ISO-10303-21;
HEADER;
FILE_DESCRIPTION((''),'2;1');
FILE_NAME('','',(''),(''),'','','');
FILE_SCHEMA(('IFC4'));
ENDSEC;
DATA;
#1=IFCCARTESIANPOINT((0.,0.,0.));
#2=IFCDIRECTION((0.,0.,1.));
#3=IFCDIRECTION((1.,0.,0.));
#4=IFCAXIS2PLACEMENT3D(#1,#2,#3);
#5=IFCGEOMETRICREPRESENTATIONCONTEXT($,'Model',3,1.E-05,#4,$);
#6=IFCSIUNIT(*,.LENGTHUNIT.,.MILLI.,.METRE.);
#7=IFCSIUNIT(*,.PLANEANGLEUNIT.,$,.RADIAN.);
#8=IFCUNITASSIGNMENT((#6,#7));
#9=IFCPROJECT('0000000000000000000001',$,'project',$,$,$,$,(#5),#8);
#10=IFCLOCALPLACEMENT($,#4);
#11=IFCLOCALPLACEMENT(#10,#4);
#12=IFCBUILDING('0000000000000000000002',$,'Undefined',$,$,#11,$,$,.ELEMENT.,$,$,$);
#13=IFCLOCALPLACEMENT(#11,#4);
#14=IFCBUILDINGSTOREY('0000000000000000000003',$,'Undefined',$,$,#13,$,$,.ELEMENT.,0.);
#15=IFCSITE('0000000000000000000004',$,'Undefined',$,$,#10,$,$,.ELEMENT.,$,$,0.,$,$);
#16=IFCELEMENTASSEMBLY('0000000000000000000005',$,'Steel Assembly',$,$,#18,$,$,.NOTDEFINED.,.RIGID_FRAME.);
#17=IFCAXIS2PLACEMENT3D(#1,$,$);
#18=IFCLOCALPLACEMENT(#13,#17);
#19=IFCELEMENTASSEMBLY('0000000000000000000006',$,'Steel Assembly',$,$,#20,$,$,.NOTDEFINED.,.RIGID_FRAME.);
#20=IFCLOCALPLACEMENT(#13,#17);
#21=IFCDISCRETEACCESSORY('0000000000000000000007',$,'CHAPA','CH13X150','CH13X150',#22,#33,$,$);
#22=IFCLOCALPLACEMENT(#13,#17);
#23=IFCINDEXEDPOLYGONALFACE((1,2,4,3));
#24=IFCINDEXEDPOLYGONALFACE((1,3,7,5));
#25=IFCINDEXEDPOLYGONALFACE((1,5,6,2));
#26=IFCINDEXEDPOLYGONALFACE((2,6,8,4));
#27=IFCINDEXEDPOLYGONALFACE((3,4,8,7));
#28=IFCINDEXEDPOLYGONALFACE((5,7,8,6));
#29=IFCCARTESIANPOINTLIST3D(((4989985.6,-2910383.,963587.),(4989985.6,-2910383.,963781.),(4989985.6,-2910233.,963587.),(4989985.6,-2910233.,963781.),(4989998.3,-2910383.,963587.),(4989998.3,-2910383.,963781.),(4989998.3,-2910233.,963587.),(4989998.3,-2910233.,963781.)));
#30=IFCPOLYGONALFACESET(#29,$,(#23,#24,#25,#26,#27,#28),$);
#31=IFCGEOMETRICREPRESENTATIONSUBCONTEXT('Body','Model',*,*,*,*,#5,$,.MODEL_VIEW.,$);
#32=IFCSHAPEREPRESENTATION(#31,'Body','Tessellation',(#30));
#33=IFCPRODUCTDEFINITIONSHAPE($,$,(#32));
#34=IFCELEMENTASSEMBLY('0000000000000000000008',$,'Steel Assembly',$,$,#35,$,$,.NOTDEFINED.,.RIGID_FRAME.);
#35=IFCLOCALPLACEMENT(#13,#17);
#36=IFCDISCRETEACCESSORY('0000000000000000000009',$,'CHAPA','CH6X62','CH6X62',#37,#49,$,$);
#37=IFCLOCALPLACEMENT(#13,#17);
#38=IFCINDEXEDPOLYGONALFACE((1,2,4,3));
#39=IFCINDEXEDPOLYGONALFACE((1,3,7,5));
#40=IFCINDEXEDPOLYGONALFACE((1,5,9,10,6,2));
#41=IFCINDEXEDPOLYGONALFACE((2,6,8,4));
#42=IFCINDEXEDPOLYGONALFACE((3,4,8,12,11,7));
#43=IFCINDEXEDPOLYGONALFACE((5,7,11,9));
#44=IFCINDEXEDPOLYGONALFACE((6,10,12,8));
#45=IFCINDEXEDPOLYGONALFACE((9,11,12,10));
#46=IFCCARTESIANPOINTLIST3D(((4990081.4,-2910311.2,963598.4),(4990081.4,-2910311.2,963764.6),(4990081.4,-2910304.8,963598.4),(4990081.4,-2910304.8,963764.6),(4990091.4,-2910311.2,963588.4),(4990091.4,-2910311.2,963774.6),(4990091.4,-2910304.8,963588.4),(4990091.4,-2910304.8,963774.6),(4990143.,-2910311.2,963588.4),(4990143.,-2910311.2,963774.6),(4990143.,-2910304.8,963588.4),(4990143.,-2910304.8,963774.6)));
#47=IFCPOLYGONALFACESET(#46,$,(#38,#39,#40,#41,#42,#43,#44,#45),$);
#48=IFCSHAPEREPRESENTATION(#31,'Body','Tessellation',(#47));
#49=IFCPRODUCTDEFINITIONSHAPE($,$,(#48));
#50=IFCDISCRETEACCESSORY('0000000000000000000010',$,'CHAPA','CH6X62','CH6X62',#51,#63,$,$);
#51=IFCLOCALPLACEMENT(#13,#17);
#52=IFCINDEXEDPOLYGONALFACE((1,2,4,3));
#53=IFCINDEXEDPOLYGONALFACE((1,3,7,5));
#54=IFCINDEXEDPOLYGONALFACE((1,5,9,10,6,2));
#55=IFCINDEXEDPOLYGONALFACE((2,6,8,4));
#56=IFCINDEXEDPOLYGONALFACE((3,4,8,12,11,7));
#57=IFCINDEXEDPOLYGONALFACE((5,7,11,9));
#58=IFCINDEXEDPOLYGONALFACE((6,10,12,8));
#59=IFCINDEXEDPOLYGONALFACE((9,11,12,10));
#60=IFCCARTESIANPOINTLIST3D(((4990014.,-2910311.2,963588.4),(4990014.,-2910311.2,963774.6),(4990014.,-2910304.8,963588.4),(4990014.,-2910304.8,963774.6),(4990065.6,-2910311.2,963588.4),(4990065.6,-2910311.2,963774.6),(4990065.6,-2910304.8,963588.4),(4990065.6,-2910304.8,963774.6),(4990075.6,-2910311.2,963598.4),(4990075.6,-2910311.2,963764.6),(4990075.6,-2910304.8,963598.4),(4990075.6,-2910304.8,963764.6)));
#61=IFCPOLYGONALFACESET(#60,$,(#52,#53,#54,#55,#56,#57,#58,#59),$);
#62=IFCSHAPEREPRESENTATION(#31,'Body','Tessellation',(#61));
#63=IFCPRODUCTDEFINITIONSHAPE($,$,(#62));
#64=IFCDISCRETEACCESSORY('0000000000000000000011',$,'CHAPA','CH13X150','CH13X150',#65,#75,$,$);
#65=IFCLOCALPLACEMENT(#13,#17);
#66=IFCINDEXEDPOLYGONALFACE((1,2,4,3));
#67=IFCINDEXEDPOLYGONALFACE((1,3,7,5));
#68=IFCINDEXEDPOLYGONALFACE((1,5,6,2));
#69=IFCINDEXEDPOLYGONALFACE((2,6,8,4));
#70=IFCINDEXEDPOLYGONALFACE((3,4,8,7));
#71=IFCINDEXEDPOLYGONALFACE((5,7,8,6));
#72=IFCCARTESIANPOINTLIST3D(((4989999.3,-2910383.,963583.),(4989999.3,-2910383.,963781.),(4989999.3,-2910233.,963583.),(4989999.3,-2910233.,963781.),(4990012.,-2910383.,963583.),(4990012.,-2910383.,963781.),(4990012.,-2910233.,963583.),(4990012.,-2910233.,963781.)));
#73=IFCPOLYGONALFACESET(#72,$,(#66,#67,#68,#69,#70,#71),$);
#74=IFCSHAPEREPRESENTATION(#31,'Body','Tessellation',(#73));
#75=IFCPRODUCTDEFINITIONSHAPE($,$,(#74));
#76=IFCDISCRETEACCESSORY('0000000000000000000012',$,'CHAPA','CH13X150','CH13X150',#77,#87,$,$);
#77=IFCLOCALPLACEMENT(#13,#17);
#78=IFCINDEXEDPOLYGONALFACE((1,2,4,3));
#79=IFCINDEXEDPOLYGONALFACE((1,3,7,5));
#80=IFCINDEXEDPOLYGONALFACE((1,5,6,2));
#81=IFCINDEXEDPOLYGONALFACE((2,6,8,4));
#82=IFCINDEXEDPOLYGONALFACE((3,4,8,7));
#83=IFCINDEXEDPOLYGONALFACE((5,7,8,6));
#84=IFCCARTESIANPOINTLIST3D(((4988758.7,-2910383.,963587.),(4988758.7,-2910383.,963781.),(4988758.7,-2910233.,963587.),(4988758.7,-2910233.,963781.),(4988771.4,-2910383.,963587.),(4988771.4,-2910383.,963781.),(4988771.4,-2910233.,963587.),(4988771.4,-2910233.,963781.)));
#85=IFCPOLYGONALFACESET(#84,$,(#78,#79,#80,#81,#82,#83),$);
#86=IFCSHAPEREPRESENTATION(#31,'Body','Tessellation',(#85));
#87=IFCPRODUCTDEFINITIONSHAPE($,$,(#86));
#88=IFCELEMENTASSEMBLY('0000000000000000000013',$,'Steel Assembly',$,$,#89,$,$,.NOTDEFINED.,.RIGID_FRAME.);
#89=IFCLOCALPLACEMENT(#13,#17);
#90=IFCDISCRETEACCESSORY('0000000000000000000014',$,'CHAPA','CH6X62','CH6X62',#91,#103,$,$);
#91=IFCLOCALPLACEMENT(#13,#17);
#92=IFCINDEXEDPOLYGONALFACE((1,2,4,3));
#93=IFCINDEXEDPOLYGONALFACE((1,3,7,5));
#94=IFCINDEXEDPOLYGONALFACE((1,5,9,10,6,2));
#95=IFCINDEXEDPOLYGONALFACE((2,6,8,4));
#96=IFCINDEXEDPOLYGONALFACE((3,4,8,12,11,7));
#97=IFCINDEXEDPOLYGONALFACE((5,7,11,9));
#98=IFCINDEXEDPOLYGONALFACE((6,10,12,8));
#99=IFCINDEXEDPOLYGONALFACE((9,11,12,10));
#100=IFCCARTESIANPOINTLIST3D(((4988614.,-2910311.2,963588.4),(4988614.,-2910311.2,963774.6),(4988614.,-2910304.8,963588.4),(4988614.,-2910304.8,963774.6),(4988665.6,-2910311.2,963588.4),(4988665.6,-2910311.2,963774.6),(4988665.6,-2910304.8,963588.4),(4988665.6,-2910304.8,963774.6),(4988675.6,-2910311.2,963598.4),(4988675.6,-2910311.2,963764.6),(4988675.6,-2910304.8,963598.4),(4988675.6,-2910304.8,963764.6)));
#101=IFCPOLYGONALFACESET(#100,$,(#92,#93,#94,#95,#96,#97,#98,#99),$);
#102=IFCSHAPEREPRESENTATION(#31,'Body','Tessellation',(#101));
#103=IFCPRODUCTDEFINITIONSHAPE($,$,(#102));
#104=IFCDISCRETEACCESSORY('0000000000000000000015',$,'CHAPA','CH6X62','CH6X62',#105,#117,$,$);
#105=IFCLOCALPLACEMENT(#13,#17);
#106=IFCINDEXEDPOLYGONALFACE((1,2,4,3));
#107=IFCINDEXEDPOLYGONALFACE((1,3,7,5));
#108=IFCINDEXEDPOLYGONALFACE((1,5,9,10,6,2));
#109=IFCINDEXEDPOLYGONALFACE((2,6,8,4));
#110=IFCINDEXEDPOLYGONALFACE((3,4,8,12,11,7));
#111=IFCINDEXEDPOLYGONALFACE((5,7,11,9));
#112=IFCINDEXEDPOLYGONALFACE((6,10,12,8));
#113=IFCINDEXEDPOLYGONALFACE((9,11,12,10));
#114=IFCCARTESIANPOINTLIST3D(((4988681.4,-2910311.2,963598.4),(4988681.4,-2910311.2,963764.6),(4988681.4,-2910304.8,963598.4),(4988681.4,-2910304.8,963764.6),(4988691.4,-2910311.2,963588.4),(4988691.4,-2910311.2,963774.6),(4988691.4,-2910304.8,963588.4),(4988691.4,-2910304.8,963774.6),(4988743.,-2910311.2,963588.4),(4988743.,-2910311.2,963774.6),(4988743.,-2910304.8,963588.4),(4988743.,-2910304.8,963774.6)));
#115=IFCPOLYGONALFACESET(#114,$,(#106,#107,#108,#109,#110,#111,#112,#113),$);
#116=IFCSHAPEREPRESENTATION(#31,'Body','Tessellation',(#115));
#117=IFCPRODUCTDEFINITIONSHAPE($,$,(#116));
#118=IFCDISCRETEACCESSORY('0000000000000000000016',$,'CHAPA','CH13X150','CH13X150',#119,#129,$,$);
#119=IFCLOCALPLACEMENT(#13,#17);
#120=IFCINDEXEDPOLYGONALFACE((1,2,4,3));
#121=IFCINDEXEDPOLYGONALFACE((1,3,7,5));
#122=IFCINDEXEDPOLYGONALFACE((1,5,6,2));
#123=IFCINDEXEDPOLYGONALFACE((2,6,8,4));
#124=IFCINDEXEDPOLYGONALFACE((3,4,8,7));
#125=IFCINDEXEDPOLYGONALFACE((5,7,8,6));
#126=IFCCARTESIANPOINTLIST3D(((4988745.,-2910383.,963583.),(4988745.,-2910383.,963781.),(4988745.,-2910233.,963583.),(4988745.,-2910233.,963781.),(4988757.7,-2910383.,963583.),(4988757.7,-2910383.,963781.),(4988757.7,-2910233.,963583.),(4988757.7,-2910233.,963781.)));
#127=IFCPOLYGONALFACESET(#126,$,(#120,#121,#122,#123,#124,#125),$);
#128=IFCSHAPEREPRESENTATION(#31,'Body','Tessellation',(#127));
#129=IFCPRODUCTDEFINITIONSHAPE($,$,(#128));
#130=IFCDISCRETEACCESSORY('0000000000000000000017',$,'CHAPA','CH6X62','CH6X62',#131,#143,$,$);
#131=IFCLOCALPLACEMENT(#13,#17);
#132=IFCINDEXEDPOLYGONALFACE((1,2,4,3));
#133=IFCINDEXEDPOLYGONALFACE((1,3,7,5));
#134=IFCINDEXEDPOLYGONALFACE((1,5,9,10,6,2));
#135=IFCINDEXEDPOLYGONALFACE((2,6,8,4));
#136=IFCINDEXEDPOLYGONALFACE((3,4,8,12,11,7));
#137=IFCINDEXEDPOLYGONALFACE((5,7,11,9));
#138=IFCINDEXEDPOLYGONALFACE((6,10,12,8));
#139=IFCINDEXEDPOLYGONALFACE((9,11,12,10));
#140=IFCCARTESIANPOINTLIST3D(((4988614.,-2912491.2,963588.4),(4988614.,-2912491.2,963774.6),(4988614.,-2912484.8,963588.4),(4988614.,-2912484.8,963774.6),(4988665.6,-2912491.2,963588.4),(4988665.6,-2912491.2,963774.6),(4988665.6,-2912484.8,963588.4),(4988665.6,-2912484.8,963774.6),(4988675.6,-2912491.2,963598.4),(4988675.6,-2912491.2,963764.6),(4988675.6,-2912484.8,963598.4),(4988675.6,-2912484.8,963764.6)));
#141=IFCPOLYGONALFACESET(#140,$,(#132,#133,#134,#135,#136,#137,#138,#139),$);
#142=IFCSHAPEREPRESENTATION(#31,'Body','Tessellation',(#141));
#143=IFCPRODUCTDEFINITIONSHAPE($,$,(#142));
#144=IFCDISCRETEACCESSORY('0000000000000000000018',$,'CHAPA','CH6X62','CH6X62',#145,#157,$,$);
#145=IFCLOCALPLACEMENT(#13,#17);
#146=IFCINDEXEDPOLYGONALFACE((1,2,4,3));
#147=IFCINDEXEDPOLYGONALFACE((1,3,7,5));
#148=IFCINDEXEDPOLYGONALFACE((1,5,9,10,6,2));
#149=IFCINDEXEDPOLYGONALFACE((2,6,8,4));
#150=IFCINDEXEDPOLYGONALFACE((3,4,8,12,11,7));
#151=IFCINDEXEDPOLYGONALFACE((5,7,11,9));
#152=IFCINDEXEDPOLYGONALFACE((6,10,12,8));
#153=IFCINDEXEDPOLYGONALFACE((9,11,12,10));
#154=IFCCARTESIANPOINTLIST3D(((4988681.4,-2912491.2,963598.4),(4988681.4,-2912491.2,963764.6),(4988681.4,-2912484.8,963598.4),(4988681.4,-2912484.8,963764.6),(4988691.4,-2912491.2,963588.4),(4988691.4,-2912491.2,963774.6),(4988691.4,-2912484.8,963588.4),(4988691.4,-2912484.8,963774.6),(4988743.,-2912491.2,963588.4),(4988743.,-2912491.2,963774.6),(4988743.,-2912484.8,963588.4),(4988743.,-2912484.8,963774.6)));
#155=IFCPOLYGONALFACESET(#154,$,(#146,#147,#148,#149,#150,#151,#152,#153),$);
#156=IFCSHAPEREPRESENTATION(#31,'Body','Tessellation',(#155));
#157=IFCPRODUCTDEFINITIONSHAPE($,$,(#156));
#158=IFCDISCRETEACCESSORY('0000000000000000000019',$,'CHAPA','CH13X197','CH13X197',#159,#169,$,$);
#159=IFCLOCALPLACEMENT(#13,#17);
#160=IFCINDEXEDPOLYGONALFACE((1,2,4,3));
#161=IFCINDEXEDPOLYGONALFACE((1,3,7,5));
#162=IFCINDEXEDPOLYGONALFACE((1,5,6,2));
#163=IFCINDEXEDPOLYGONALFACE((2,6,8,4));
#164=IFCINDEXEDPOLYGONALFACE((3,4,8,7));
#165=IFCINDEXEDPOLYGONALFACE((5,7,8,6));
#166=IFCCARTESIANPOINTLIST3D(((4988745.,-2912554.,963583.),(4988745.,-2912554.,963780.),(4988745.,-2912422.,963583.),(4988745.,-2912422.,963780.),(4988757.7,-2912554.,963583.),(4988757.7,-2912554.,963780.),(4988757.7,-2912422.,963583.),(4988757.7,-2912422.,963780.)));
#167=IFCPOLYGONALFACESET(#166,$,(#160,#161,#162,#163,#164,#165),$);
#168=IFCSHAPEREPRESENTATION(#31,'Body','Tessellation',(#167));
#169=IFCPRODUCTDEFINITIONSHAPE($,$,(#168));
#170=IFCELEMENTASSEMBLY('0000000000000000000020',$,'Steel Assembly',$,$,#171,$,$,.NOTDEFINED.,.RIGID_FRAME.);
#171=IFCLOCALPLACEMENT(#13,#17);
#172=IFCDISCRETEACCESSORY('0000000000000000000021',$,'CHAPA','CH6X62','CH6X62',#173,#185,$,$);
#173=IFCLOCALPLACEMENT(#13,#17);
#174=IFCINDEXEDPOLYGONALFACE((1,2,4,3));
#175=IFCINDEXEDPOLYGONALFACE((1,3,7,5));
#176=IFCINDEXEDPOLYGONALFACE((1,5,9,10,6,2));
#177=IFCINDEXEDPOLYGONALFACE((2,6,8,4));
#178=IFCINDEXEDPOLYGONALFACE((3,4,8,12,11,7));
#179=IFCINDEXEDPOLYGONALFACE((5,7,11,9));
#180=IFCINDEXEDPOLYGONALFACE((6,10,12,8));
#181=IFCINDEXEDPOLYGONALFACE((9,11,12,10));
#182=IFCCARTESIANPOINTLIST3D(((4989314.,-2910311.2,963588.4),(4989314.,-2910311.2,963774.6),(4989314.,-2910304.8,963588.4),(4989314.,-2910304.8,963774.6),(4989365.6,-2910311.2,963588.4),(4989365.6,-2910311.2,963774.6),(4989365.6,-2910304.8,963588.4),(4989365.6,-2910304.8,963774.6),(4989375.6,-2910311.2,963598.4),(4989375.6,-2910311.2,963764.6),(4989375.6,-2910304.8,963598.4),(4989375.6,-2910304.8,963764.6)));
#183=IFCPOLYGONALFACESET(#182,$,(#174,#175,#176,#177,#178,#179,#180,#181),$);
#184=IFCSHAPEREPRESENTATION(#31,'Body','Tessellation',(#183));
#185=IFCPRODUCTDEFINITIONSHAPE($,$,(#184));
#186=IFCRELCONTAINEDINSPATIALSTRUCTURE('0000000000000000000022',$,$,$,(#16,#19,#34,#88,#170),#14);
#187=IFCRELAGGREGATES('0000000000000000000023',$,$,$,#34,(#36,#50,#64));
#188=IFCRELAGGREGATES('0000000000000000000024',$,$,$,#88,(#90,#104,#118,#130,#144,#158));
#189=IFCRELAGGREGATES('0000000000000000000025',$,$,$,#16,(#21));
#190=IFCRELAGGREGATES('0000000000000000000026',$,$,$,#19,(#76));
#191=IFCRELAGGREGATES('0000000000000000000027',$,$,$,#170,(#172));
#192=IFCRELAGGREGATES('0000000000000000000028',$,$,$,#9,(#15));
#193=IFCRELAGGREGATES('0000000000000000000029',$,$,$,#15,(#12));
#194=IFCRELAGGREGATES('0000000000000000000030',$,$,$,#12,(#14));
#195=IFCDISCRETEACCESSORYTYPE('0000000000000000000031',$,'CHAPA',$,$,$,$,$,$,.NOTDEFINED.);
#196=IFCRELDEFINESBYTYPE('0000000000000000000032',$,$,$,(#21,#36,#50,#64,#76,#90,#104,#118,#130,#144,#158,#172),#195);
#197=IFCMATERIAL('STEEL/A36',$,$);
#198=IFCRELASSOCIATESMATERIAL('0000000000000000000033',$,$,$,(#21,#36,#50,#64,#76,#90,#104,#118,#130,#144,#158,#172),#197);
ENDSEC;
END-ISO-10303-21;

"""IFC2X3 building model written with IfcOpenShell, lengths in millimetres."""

from ifc_helpers import new_model, si_unit, frame, origin_with_axes, place, context, subcontext, project, spatial, polyline, outline, extrude, material, type_object, element, aggregate, save


model = new_model("IFC2X3")

# Units and contexts
model_context = context("Model", 3, precision=1e-05, world=origin_with_axes())
body_context = subcontext(model_context, "Body", "Model", "MODEL_VIEW")
ifc_project = project(units=[si_unit("LENGTHUNIT", "METRE", prefix="MILLI"), si_unit("PLANEANGLEUNIT", "RADIAN")], contexts=[model_context])

# Site, building, storey
site_placement = place(None, origin_with_axes())
site = spatial("IfcSite", under=ifc_project, at=site_placement, Name="Undefined", CompositionType="ELEMENT", RefElevation=0.0)
building_placement = place(site_placement, origin_with_axes())
building = spatial("IfcBuilding", under=site, at=building_placement, Name="Undefined", CompositionType="ELEMENT")
storey_placement = place(building_placement, origin_with_axes())
storey = spatial("IfcBuildingStorey", under=building, at=storey_placement, Name="Undefined", CompositionType="ELEMENT", Elevation=0.0)

# Element assemblies
assembly_1_placement = place(storey_placement, origin_with_axes())
assembly_1 = element("IfcElementAssembly", 1, at=assembly_1_placement, inside=storey, Name="Steel Assembly", AssemblyPlace="NOTDEFINED", PredefinedType="RIGID_FRAME")
assembly_2_placement = place(storey_placement, origin_with_axes())
assembly_2 = element("IfcElementAssembly", 2, at=assembly_2_placement, inside=storey, Name="Steel Assembly", AssemblyPlace="NOTDEFINED", PredefinedType="RIGID_FRAME")

# Discrete accessory
ifc_material_1 = material(Name="STEEL/A36")
discrete_accessory_type = type_object("IfcDiscreteAccessoryType", Name="CHAPA")
discrete_accessory_1_placement = place(assembly_1_placement, frame((4989991.9, -2910308.0, 963781.0), z_axis=(-1.0, 0.0, 0.0), x_axis=(0.0, 0.0, -1.0)))
discrete_accessory_1 = element("IfcDiscreteAccessory", 3, at=discrete_accessory_1_placement, type_object=discrete_accessory_type, material=ifc_material_1, Name="CHAPA", Description="CH13X150", ObjectType="CH13X150", context=body_context, shape_type="SweptSolid", body=[
    extrude(outline(polyline([(194.0, 75.0), (194.0, -75.0), (0.0, -75.0), (0.0, 75.0), (194.0, 75.0)])), frame((0.0, 0.0, -6.3), z_axis=(0.0, 0.0, 1.0), x_axis=(1.0, 0.0, 0.0)), (0.0, 0.0, 1.0), 12.7),
])

# Element assembly, discrete accessories
assembly_3_placement = place(storey_placement, origin_with_axes())
assembly_3 = element("IfcElementAssembly", 4, at=assembly_3_placement, inside=storey, Name="Steel Assembly", AssemblyPlace="NOTDEFINED", PredefinedType="RIGID_FRAME")
discrete_accessory_2_placement = place(assembly_3_placement, frame((4990081.4, -2910308.0, 963774.6), z_axis=(0.0, 1.0, 0.0), x_axis=(1.0, 0.0, 0.0)))
discrete_accessory_2 = element("IfcDiscreteAccessory", 5, at=discrete_accessory_2_placement, type_object=discrete_accessory_type, material=ifc_material_1, Name="CHAPA", Description="CH6X62", ObjectType="CH6X62", context=body_context, shape_type="SweptSolid", body=[
    extrude(outline(polyline([(0.0, 10.0), (10.0, 0.0), (61.6, 0.0), (61.6, 186.2), (10.0, 186.2), (0.0, 176.2), (0.0, 10.0)])), frame((0.0, 0.0, -3.2), z_axis=(0.0, 0.0, 1.0), x_axis=(1.0, 0.0, 0.0)), (0.0, 0.0, 1.0), 6.4),
])
discrete_accessory_3_placement = place(assembly_3_placement, frame((4990075.6, -2910308.0, 963774.6), z_axis=(0.0, -1.0, 0.0), x_axis=(-1.0, 0.0, 0.0)))
discrete_accessory_3 = element("IfcDiscreteAccessory", 6, at=discrete_accessory_3_placement, type_object=discrete_accessory_type, material=ifc_material_1, Name="CHAPA", Description="CH6X62", ObjectType="CH6X62", context=body_context, shape_type="SweptSolid", body=[
    extrude(outline(polyline([(0.0, 10.0), (10.0, 0.0), (61.6, 0.0), (61.6, 186.2), (10.0, 186.2), (0.0, 176.2), (0.0, 10.0)])), frame((0.0, 0.0, -3.2), z_axis=(0.0, 0.0, 1.0), x_axis=(1.0, 0.0, 0.0)), (0.0, 0.0, 1.0), 6.4),
])
discrete_accessory_4_placement = place(assembly_3_placement, frame((4990005.6, -2910308.0, 963781.0), z_axis=(-1.0, 0.0, 0.0), x_axis=(0.0, 0.0, -1.0)))
discrete_accessory_4 = element("IfcDiscreteAccessory", 7, at=discrete_accessory_4_placement, type_object=discrete_accessory_type, material=ifc_material_1, Name="CHAPA", Description="CH13X150", ObjectType="CH13X150", context=body_context, shape_type="SweptSolid", body=[
    extrude(outline(polyline([(198.0, 75.0), (198.0, -75.0), (0.0, -75.0), (0.0, 75.0), (198.0, 75.0)])), frame((0.0, 0.0, -6.3), z_axis=(0.0, 0.0, 1.0), x_axis=(1.0, 0.0, 0.0)), (0.0, 0.0, 1.0), 12.7),
])
aggregate(assembly_3, [discrete_accessory_2, discrete_accessory_3, discrete_accessory_4])

# Discrete accessory
discrete_accessory_5_placement = place(assembly_2_placement, frame((4988765.0, -2910308.0, 963781.0), z_axis=(1.0, 0.0, 0.0), x_axis=(0.0, 0.0, -1.0)))
discrete_accessory_5 = element("IfcDiscreteAccessory", 8, at=discrete_accessory_5_placement, type_object=discrete_accessory_type, material=ifc_material_1, Name="CHAPA", Description="CH13X150", ObjectType="CH13X150", context=body_context, shape_type="SweptSolid", body=[
    extrude(outline(polyline([(194.0, -75.0), (0.0, -75.0), (0.0, 75.0), (194.0, 75.0), (194.0, -75.0)])), frame((0.0, 0.0, -6.3), z_axis=(0.0, 0.0, 1.0), x_axis=(1.0, 0.0, 0.0)), (0.0, 0.0, 1.0), 12.7),
])

# Element assembly, discrete accessories
assembly_4_placement = place(storey_placement, origin_with_axes())
assembly_4 = element("IfcElementAssembly", 9, at=assembly_4_placement, inside=storey, Name="Steel Assembly", AssemblyPlace="NOTDEFINED", PredefinedType="RIGID_FRAME")
discrete_accessory_6_placement = place(assembly_4_placement, frame((4988675.6, -2910308.0, 963774.6), z_axis=(0.0, -1.0, 0.0), x_axis=(-1.0, 0.0, 0.0)))
discrete_accessory_6 = element("IfcDiscreteAccessory", 10, at=discrete_accessory_6_placement, type_object=discrete_accessory_type, material=ifc_material_1, Name="CHAPA", Description="CH6X62", ObjectType="CH6X62", context=body_context, shape_type="SweptSolid", body=[
    extrude(outline(polyline([(0.0, 10.0), (10.0, 0.0), (61.6, 0.0), (61.6, 186.2), (10.0, 186.2), (0.0, 176.2), (0.0, 10.0)])), frame((0.0, 0.0, -3.2), z_axis=(0.0, 0.0, 1.0), x_axis=(1.0, 0.0, 0.0)), (0.0, 0.0, 1.0), 6.4),
])
discrete_accessory_7_placement = place(assembly_4_placement, frame((4988681.4, -2910308.0, 963774.6), z_axis=(0.0, 1.0, 0.0), x_axis=(1.0, 0.0, 0.0)))
discrete_accessory_7 = element("IfcDiscreteAccessory", 11, at=discrete_accessory_7_placement, type_object=discrete_accessory_type, material=ifc_material_1, Name="CHAPA", Description="CH6X62", ObjectType="CH6X62", context=body_context, shape_type="SweptSolid", body=[
    extrude(outline(polyline([(0.0, 10.0), (10.0, 0.0), (61.6, 0.0), (61.6, 186.2), (10.0, 186.2), (0.0, 176.2), (0.0, 10.0)])), frame((0.0, 0.0, -3.2), z_axis=(0.0, 0.0, 1.0), x_axis=(1.0, 0.0, 0.0)), (0.0, 0.0, 1.0), 6.4),
])
discrete_accessory_8_placement = place(assembly_4_placement, frame((4988751.3, -2910308.0, 963781.0), z_axis=(1.0, 0.0, 0.0), x_axis=(0.0, 0.0, -1.0)))
discrete_accessory_8 = element("IfcDiscreteAccessory", 12, at=discrete_accessory_8_placement, type_object=discrete_accessory_type, material=ifc_material_1, Name="CHAPA", Description="CH13X150", ObjectType="CH13X150", context=body_context, shape_type="SweptSolid", body=[
    extrude(outline(polyline([(198.0, -75.0), (0.0, -75.0), (0.0, 75.0), (198.0, 75.0), (198.0, -75.0)])), frame((0.0, 0.0, -6.3), z_axis=(0.0, 0.0, 1.0), x_axis=(1.0, 0.0, 0.0)), (0.0, 0.0, 1.0), 12.7),
])
discrete_accessory_9_placement = place(assembly_4_placement, frame((4988675.6, -2912488.0, 963774.6), z_axis=(0.0, -1.0, 0.0), x_axis=(-1.0, 0.0, 0.0)))
discrete_accessory_9 = element("IfcDiscreteAccessory", 13, at=discrete_accessory_9_placement, type_object=discrete_accessory_type, material=ifc_material_1, Name="CHAPA", Description="CH6X62", ObjectType="CH6X62", context=body_context, shape_type="SweptSolid", body=[
    extrude(outline(polyline([(0.0, 10.0), (10.0, 0.0), (61.6, 0.0), (61.6, 186.2), (10.0, 186.2), (0.0, 176.2), (0.0, 10.0)])), frame((0.0, 0.0, -3.2), z_axis=(0.0, 0.0, 1.0), x_axis=(1.0, 0.0, 0.0)), (0.0, 0.0, 1.0), 6.4),
])
discrete_accessory_10_placement = place(assembly_4_placement, frame((4988681.4, -2912488.0, 963774.6), z_axis=(0.0, 1.0, 0.0), x_axis=(1.0, 0.0, 0.0)))
discrete_accessory_10 = element("IfcDiscreteAccessory", 14, at=discrete_accessory_10_placement, type_object=discrete_accessory_type, material=ifc_material_1, Name="CHAPA", Description="CH6X62", ObjectType="CH6X62", context=body_context, shape_type="SweptSolid", body=[
    extrude(outline(polyline([(0.0, 10.0), (10.0, 0.0), (61.6, 0.0), (61.6, 186.2), (10.0, 186.2), (0.0, 176.2), (0.0, 10.0)])), frame((0.0, 0.0, -3.2), z_axis=(0.0, 0.0, 1.0), x_axis=(1.0, 0.0, 0.0)), (0.0, 0.0, 1.0), 6.4),
])
discrete_accessory_11_placement = place(assembly_4_placement, frame((4988751.3, -2912488.0, 963780.0), z_axis=(1.0, 0.0, 0.0), x_axis=(0.0, 0.0, -1.0)))
discrete_accessory_11 = element("IfcDiscreteAccessory", 15, at=discrete_accessory_11_placement, type_object=discrete_accessory_type, material=ifc_material_1, Name="CHAPA", Description="CH13X197", ObjectType="CH13X197", context=body_context, shape_type="SweptSolid", body=[
    extrude(outline(polyline([(197.0, -66.0), (0.0, -66.0), (0.0, 66.0), (197.0, 66.0), (197.0, -66.0)])), frame((0.0, 0.0, -6.3), z_axis=(0.0, 0.0, 1.0), x_axis=(1.0, 0.0, 0.0)), (0.0, 0.0, 1.0), 12.7),
])
aggregate(assembly_4, [discrete_accessory_6, discrete_accessory_7, discrete_accessory_8, discrete_accessory_9, discrete_accessory_10, discrete_accessory_11])

# Element assembly, discrete accessory
assembly_5_placement = place(storey_placement, origin_with_axes())
assembly_5 = element("IfcElementAssembly", 16, at=assembly_5_placement, inside=storey, Name="Steel Assembly", AssemblyPlace="NOTDEFINED", PredefinedType="RIGID_FRAME")
discrete_accessory_12_placement = place(assembly_5_placement, frame((4989375.6, -2910308.0, 963774.6), z_axis=(0.0, -1.0, 0.0), x_axis=(-1.0, 0.0, 0.0)))
discrete_accessory_12 = element("IfcDiscreteAccessory", 17, at=discrete_accessory_12_placement, type_object=discrete_accessory_type, material=ifc_material_1, Name="CHAPA", Description="CH6X62", ObjectType="CH6X62", context=body_context, shape_type="SweptSolid", body=[
    extrude(outline(polyline([(0.0, 10.0), (10.0, 0.0), (61.6, 0.0), (61.6, 186.2), (10.0, 186.2), (0.0, 176.2), (0.0, 10.0)])), frame((0.0, 0.0, -3.2), z_axis=(0.0, 0.0, 1.0), x_axis=(1.0, 0.0, 0.0)), (0.0, 0.0, 1.0), 6.4),
])

aggregate(assembly_1, [discrete_accessory_1])
aggregate(assembly_2, [discrete_accessory_5])

aggregate(assembly_5, [discrete_accessory_12])

save(model, "model.ifc")
